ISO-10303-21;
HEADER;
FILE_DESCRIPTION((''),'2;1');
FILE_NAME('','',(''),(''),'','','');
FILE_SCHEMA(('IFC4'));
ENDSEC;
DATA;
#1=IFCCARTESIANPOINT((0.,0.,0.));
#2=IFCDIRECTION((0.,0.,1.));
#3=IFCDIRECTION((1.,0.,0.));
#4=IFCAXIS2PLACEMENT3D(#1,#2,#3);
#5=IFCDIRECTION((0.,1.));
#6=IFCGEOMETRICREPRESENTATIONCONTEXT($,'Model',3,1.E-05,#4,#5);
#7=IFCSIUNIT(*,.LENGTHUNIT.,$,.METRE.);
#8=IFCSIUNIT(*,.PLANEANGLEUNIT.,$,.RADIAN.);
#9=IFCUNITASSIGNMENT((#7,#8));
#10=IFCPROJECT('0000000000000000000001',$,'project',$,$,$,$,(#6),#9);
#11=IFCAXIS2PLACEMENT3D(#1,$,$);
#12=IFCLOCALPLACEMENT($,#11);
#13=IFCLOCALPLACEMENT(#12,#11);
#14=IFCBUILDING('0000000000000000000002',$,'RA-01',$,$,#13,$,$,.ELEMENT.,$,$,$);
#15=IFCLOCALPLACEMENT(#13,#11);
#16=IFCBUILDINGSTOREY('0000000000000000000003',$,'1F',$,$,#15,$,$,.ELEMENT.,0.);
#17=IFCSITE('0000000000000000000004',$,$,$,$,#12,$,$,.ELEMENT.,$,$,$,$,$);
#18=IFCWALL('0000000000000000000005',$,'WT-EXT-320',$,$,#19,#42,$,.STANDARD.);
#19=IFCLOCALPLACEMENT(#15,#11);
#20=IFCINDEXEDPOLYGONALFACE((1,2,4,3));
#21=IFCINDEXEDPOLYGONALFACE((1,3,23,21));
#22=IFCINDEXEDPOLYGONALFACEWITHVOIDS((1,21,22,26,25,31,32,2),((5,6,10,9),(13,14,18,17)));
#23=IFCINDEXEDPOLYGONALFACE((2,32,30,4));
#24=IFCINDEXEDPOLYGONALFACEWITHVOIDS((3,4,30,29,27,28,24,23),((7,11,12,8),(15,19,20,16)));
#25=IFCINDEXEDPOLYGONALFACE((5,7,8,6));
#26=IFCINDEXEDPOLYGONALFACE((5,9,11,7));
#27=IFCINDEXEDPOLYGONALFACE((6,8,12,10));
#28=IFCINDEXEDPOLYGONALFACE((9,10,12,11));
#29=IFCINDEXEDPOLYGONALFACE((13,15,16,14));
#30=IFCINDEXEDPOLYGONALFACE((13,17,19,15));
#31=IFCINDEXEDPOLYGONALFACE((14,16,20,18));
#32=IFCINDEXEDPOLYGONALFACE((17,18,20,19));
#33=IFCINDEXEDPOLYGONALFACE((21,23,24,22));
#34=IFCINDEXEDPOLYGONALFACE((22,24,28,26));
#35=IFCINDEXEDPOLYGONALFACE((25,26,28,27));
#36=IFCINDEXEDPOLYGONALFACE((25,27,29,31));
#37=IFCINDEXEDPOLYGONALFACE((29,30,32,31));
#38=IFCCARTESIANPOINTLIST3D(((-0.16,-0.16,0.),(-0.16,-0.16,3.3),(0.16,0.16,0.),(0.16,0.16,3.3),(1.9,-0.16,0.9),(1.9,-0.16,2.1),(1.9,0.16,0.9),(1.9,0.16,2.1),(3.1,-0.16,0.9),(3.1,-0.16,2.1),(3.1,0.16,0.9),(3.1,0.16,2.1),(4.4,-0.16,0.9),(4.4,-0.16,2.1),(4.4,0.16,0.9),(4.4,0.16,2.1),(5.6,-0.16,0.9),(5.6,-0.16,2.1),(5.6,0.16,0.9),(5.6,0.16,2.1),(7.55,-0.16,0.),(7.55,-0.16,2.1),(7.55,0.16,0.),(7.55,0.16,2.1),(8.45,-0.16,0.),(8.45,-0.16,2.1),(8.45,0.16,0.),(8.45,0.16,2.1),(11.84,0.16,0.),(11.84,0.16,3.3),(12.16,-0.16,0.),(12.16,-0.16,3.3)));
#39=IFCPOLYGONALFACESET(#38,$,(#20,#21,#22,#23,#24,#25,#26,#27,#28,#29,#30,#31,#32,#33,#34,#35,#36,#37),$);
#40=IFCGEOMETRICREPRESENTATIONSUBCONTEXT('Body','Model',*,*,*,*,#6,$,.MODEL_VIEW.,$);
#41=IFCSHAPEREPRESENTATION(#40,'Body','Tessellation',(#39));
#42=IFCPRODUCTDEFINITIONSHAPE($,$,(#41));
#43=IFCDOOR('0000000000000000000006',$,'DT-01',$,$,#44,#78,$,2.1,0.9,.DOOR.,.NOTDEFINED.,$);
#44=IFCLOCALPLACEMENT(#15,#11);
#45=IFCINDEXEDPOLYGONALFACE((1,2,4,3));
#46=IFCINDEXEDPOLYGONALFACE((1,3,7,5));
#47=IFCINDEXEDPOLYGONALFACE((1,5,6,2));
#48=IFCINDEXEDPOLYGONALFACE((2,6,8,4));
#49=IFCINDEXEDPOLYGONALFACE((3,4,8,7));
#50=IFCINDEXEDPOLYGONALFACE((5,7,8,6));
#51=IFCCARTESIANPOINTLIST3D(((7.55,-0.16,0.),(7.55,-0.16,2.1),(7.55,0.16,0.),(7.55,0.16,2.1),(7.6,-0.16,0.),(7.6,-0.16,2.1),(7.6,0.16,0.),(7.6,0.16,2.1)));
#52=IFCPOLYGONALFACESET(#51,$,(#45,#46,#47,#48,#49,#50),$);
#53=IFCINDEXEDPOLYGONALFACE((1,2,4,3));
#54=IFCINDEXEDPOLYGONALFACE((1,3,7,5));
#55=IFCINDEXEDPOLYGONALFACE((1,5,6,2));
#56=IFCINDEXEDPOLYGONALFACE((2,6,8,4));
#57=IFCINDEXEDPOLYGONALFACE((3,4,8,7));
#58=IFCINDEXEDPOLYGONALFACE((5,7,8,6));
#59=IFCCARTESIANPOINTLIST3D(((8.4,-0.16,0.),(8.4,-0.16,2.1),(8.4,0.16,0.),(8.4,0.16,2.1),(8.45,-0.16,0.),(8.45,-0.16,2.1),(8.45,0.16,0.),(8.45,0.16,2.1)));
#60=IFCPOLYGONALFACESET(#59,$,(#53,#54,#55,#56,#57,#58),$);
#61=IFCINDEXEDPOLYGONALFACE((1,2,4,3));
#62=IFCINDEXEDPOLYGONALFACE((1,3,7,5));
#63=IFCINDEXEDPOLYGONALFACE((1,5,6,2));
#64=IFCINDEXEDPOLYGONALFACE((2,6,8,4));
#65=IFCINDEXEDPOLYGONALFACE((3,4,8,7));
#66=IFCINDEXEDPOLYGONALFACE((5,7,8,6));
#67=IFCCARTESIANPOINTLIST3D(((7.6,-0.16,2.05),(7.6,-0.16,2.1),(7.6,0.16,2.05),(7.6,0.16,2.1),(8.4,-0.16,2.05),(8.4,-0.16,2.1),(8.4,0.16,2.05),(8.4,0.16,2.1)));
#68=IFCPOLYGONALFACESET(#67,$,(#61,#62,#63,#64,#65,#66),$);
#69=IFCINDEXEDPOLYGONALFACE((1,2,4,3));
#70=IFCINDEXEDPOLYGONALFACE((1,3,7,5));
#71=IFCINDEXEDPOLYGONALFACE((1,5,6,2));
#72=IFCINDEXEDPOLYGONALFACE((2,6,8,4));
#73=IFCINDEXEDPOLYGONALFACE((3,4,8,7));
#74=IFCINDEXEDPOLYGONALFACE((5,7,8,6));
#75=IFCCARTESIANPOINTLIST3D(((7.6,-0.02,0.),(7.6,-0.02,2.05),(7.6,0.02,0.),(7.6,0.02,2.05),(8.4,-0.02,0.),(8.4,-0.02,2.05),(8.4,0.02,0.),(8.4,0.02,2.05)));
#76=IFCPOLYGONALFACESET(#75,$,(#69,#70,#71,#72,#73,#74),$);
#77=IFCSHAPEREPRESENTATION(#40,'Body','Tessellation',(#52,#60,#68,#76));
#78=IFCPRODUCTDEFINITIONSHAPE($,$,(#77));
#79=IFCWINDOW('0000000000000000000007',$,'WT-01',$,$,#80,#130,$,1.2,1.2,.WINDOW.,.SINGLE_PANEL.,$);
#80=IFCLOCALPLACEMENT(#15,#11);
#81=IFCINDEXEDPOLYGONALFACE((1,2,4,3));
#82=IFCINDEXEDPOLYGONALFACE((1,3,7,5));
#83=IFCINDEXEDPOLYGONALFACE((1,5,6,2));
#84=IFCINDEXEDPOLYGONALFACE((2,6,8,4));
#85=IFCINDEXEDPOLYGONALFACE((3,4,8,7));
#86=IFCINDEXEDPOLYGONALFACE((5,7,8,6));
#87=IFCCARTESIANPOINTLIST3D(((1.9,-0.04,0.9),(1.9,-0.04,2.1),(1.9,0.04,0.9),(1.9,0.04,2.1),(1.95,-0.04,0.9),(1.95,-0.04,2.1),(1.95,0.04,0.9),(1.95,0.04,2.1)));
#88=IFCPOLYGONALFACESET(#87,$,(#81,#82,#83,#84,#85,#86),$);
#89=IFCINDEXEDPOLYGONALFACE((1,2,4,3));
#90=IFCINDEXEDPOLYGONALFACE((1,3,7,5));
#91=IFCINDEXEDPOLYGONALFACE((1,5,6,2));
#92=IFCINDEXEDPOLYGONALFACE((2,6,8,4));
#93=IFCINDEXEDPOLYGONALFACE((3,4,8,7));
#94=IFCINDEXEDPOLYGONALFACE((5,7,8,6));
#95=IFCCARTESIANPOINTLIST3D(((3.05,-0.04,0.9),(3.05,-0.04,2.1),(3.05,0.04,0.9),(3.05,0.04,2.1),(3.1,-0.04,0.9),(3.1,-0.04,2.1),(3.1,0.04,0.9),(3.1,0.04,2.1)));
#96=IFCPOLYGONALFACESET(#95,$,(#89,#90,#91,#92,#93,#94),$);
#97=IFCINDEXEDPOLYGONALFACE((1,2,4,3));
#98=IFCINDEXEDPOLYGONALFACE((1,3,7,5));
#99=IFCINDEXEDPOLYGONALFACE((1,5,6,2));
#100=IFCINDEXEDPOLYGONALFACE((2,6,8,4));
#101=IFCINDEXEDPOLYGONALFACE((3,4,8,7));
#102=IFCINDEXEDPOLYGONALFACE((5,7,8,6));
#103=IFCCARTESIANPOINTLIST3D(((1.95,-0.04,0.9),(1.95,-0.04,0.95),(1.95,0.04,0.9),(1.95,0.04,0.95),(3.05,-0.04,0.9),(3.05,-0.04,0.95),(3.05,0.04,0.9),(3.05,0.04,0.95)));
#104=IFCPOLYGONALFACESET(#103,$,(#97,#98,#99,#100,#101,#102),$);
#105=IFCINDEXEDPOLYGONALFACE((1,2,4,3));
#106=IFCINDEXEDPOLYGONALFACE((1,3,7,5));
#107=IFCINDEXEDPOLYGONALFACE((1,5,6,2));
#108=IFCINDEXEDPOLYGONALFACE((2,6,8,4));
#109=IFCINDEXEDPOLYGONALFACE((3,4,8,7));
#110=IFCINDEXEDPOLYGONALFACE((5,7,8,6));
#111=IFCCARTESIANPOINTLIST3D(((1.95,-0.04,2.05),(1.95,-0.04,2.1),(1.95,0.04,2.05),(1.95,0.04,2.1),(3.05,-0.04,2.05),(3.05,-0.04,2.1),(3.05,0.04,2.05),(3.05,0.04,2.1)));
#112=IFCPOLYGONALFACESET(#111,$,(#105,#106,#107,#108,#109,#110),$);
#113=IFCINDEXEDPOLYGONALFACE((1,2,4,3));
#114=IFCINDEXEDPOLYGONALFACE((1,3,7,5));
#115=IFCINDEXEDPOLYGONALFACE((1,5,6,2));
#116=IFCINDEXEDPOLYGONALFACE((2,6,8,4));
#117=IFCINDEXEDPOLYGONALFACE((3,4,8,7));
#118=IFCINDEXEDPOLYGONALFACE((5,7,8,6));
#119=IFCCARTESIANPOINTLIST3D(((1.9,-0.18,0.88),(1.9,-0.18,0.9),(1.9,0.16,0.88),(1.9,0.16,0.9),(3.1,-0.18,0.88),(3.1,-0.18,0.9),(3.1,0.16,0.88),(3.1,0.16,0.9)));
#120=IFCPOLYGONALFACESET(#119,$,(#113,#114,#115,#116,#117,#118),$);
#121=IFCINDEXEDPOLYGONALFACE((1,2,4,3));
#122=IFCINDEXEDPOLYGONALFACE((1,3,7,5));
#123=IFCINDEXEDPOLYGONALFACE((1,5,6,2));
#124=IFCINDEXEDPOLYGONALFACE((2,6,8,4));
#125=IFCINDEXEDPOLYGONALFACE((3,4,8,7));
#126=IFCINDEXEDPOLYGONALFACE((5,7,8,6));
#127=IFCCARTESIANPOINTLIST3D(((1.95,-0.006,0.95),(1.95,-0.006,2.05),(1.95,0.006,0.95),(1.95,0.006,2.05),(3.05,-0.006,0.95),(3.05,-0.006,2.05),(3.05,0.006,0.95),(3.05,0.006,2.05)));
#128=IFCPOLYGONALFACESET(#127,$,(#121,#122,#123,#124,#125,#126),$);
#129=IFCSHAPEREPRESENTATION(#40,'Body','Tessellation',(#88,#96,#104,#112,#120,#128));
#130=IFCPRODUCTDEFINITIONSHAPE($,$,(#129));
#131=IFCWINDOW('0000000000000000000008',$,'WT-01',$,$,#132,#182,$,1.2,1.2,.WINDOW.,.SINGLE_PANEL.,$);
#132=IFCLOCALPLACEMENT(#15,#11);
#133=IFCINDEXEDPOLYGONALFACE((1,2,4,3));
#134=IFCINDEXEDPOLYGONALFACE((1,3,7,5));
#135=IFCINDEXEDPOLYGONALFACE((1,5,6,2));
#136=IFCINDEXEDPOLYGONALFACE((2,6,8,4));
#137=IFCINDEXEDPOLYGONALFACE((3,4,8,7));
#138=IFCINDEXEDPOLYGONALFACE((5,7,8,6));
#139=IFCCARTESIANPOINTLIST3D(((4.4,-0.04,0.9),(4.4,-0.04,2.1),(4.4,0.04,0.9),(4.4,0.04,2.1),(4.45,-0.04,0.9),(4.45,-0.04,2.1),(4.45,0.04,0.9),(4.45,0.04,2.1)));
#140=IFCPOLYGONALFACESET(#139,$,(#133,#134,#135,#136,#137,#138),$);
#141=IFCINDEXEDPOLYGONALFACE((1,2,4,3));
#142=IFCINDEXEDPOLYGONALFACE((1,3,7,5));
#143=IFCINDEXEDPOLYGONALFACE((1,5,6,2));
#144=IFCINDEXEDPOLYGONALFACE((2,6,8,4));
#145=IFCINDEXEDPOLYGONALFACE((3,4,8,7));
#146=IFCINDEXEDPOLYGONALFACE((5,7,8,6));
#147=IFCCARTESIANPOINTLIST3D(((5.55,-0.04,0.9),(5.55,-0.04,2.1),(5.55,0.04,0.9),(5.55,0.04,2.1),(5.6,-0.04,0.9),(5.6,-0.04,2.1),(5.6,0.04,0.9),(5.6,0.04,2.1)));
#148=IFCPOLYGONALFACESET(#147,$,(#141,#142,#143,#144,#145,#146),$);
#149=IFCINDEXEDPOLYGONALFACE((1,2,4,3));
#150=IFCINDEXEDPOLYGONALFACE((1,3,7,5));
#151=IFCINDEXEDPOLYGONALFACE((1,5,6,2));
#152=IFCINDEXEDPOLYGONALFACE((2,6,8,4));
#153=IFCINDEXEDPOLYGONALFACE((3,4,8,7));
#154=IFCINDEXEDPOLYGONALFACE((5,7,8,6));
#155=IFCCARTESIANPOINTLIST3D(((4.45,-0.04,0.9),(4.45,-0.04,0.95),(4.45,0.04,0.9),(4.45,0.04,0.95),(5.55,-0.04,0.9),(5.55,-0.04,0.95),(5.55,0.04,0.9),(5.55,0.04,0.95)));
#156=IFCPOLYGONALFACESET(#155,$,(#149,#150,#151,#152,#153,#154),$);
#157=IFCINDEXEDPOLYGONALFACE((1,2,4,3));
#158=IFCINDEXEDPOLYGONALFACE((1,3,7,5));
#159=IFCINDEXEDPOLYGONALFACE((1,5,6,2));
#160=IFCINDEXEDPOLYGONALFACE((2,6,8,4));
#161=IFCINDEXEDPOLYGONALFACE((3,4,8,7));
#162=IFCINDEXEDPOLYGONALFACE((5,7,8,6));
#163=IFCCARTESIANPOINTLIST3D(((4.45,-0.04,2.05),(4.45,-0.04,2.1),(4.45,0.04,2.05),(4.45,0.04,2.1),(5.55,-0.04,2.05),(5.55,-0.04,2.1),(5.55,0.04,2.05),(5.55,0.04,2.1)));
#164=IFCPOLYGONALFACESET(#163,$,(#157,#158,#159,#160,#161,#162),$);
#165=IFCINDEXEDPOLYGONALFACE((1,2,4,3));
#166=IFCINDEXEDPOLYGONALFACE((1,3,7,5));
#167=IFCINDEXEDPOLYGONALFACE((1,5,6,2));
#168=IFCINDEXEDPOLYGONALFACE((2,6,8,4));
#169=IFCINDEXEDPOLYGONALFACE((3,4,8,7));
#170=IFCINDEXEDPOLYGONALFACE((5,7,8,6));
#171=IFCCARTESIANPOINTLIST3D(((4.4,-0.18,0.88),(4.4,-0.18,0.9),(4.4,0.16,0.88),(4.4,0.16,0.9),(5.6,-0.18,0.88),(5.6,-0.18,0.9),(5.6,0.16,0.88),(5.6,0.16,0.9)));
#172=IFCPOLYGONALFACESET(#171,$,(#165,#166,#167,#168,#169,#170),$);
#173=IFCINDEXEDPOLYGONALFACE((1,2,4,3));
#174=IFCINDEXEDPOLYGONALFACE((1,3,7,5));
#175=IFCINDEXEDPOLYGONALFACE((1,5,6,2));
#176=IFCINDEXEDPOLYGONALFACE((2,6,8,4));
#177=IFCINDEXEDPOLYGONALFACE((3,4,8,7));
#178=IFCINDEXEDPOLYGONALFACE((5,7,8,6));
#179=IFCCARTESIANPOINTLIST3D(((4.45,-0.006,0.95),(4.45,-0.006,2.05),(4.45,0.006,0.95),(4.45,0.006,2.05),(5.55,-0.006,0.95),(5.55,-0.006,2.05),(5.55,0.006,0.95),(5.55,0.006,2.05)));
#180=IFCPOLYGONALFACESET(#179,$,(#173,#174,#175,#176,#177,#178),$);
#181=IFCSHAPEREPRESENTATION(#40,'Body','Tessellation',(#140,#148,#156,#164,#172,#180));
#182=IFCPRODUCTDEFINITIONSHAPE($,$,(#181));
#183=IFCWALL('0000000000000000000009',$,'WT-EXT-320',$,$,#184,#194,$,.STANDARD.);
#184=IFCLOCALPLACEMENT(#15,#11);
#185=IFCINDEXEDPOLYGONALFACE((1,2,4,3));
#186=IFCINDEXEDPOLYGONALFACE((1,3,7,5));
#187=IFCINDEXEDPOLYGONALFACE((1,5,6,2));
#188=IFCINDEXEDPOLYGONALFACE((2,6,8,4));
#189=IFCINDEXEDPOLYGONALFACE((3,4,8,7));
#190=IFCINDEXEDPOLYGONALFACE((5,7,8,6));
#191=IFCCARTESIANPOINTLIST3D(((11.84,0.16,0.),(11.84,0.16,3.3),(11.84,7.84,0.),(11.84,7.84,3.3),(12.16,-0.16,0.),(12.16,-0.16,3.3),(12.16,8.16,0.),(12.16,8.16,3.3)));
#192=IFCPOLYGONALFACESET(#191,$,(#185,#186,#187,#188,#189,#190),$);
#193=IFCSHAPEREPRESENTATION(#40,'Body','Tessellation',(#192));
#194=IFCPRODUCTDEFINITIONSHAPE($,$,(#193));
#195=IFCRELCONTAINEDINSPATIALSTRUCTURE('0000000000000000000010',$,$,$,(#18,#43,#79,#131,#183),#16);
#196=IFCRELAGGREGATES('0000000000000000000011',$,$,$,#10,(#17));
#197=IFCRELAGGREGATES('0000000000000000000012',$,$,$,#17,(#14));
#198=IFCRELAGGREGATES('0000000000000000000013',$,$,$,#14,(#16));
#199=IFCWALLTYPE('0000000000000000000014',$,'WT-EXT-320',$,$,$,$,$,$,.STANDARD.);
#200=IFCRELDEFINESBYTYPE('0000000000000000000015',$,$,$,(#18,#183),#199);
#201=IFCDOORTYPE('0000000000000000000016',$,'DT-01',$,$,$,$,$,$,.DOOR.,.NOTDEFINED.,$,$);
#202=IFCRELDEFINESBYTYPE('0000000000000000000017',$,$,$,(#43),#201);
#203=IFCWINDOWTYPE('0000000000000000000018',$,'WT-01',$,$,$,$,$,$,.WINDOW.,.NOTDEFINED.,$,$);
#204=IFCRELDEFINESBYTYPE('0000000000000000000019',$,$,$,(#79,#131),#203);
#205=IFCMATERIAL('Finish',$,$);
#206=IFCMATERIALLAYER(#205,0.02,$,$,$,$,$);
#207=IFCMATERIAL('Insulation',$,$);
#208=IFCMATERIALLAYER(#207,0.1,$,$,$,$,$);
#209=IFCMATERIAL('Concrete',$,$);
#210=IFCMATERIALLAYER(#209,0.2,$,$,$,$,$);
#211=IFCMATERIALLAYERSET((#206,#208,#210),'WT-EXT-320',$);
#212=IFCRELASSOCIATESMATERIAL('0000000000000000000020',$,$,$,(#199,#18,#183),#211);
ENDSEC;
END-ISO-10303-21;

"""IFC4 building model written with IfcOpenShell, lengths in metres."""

from ifc_helpers import new_model, si_unit, direction, frame, frame_2d, origin, origin_with_axes, place, context, subcontext, project, spatial, polyline, rectangle, outline, extrude, material, layer, layer_set, layer_usage, type_object, element, fill, save


model = new_model("IFC4")

# Units and contexts
model_context = context("Model", 3, precision=1e-05, world=origin_with_axes(), true_north=direction((0.0, 1.0)))
body_context = subcontext(model_context, "Body", "Model", "MODEL_VIEW")
ifc_project = project(units=[si_unit("LENGTHUNIT", "METRE"), si_unit("PLANEANGLEUNIT", "RADIAN")], contexts=[model_context])

# Site, building, storey
site_placement = place(None, origin())
site = spatial("IfcSite", under=ifc_project, at=site_placement, CompositionType="ELEMENT")
building_placement = place(site_placement, origin())
building = spatial("IfcBuilding", under=site, at=building_placement, Name="RA-01", CompositionType="ELEMENT")
storey_placement = place(building_placement, origin())
storey = spatial("IfcBuildingStorey", under=building, at=storey_placement, Name="1F", CompositionType="ELEMENT", Elevation=0.0)

# Shared definitions
ifc_material_1 = material(Name="Concrete")

# Wall, openings, door, windows
ifc_material_2 = material(Name="Finish")
ifc_layer_1 = layer(ifc_material_2, 0.02)
ifc_material_3 = material(Name="Insulation")
ifc_layer_2 = layer(ifc_material_3, 0.1)
ifc_layer_3 = layer(ifc_material_1, 0.2)
ifc_layer_set_1 = layer_set([ifc_layer_1, ifc_layer_2, ifc_layer_3], Name="WT-EXT-320")
ifc_layer_usage_1 = layer_usage(ifc_layer_set_1, "AXIS2", "NEGATIVE", 0.16)
wall_type_1 = type_object("IfcWallType", Name="WT-EXT-320", PredefinedType="STANDARD", material=ifc_layer_set_1)
wall_1_placement = place(storey_placement, origin())
wall_1 = element("IfcWall", 1, at=wall_1_placement, inside=storey, type_object=wall_type_1, material=ifc_layer_usage_1, Name="WT-EXT-320", PredefinedType="STANDARD", context=body_context, shape_type="SweptSolid", body=[
    extrude(outline(polyline([(-0.16, -0.16), (12.16, -0.16), (11.84, 0.16), (0.16, 0.16), (-0.16, -0.16)])), origin(), (0.0, 0.0, 1.0), 3.3),
])
opening_1_placement = place(wall_1_placement, frame((7.55, 0.0, 0.0)))
opening_1 = element("IfcOpeningElement", 2, at=opening_1_placement, cuts=wall_1, PredefinedType="OPENING", context=body_context, shape_type="SweptSolid", body=[
    extrude(rectangle(XDim=0.9, YDim=0.42, at=frame_2d((0.45, 0.0))), origin(), (0.0, 0.0, 1.0), 2.1),
])
opening_2_placement = place(wall_1_placement, frame((1.9, 0.0, 0.9)))
opening_2 = element("IfcOpeningElement", 3, at=opening_2_placement, cuts=wall_1, PredefinedType="OPENING", context=body_context, shape_type="SweptSolid", body=[
    extrude(rectangle(XDim=1.2, YDim=0.42, at=frame_2d((0.6, 0.0))), origin(), (0.0, 0.0, 1.0), 1.2),
])
opening_3_placement = place(wall_1_placement, frame((4.4, 0.0, 0.9)))
opening_3 = element("IfcOpeningElement", 4, at=opening_3_placement, cuts=wall_1, PredefinedType="OPENING", context=body_context, shape_type="SweptSolid", body=[
    extrude(rectangle(XDim=1.2, YDim=0.42, at=frame_2d((0.6, 0.0))), origin(), (0.0, 0.0, 1.0), 1.2),
])
door_type_1 = type_object("IfcDoorType", Name="DT-01", OperationType="NOTDEFINED", PredefinedType="DOOR")
door_1_placement = place(opening_1_placement, origin())
door_1 = element("IfcDoor", 5, at=door_1_placement, inside=storey, type_object=door_type_1, Name="DT-01", OperationType="NOTDEFINED", OverallHeight=2.1, OverallWidth=0.9, PredefinedType="DOOR", context=body_context, shape_type="SweptSolid", body=[
    extrude(outline(polyline([(0.0, -0.16), (0.05, -0.16), (0.05, 0.16), (0.0, 0.16), (0.0, -0.16)])), origin(), (0.0, 0.0, 1.0), 2.1),
    extrude(outline(polyline([(0.85, -0.16), (0.9, -0.16), (0.9, 0.16), (0.85, 0.16), (0.85, -0.16)])), origin(), (0.0, 0.0, 1.0), 2.1),
    extrude(outline(polyline([(0.05, -0.16), (0.85, -0.16), (0.85, 0.16), (0.05, 0.16), (0.05, -0.16)])), frame((0.0, 0.0, 2.05)), (0.0, 0.0, 1.0), 0.05),
    extrude(outline(polyline([(0.05, -0.02), (0.85, -0.02), (0.85, 0.02), (0.05, 0.02), (0.05, -0.02)])), origin(), (0.0, 0.0, 1.0), 2.05),
])
fill(opening_1, door_1)
window_type_1 = type_object("IfcWindowType", Name="WT-01", PartitioningType="NOTDEFINED", PredefinedType="WINDOW")
window_1_placement = place(opening_2_placement, origin())
window_1 = element("IfcWindow", 6, at=window_1_placement, inside=storey, type_object=window_type_1, Name="WT-01", OverallHeight=1.2, OverallWidth=1.2, PartitioningType="SINGLE_PANEL", PredefinedType="WINDOW", context=body_context, shape_type="SweptSolid", body=[
    extrude(outline(polyline([(0.0, -0.04), (0.05, -0.04), (0.05, 0.04), (0.0, 0.04), (0.0, -0.04)])), origin(), (0.0, 0.0, 1.0), 1.2),
    extrude(outline(polyline([(1.15, -0.04), (1.2, -0.04), (1.2, 0.04), (1.15, 0.04), (1.15, -0.04)])), origin(), (0.0, 0.0, 1.0), 1.2),
    extrude(outline(polyline([(0.05, -0.04), (1.15, -0.04), (1.15, 0.04), (0.05, 0.04), (0.05, -0.04)])), origin(), (0.0, 0.0, 1.0), 0.05),
    extrude(outline(polyline([(0.05, -0.04), (1.15, -0.04), (1.15, 0.04), (0.05, 0.04), (0.05, -0.04)])), frame((0.0, 0.0, 1.15)), (0.0, 0.0, 1.0), 0.05),
    extrude(outline(polyline([(0.0, -0.18), (1.2, -0.18), (1.2, 0.16), (0.0, 0.16), (0.0, -0.18)])), frame((0.0, 0.0, -0.02)), (0.0, 0.0, 1.0), 0.02),
    extrude(outline(polyline([(0.05, -0.006), (1.15, -0.006), (1.15, 0.006), (0.05, 0.006), (0.05, -0.006)])), frame((0.0, 0.0, 0.05)), (0.0, 0.0, 1.0), 1.1),
])
fill(opening_2, window_1)
window_2_placement = place(opening_3_placement, origin())
window_2 = element("IfcWindow", 7, at=window_2_placement, inside=storey, type_object=window_type_1, Name="WT-01", OverallHeight=1.2, OverallWidth=1.2, PartitioningType="SINGLE_PANEL", PredefinedType="WINDOW", context=body_context, shape_type="SweptSolid", body=[
    extrude(outline(polyline([(0.0, -0.04), (0.05, -0.04), (0.05, 0.04), (0.0, 0.04), (0.0, -0.04)])), origin(), (0.0, 0.0, 1.0), 1.2),
    extrude(outline(polyline([(1.15, -0.04), (1.2, -0.04), (1.2, 0.04), (1.15, 0.04), (1.15, -0.04)])), origin(), (0.0, 0.0, 1.0), 1.2),
    extrude(outline(polyline([(0.05, -0.04), (1.15, -0.04), (1.15, 0.04), (0.05, 0.04), (0.05, -0.04)])), origin(), (0.0, 0.0, 1.0), 0.05),
    extrude(outline(polyline([(0.05, -0.04), (1.15, -0.04), (1.15, 0.04), (0.05, 0.04), (0.05, -0.04)])), frame((0.0, 0.0, 1.15)), (0.0, 0.0, 1.0), 0.05),
    extrude(outline(polyline([(0.0, -0.18), (1.2, -0.18), (1.2, 0.16), (0.0, 0.16), (0.0, -0.18)])), frame((0.0, 0.0, -0.02)), (0.0, 0.0, 1.0), 0.02),
    extrude(outline(polyline([(0.05, -0.006), (1.15, -0.006), (1.15, 0.006), (0.05, 0.006), (0.05, -0.006)])), frame((0.0, 0.0, 0.05)), (0.0, 0.0, 1.0), 1.1),
])
fill(opening_3, window_2)

# Wall
wall_2_placement = place(storey_placement, frame((12.0, 0.0, 0.0), z_axis=(0.0, 0.0, 1.0), x_axis=(0.0, 1.0, 0.0)))
element("IfcWall", 8, at=wall_2_placement, inside=storey, type_object=wall_type_1, material=ifc_layer_usage_1, Name="WT-EXT-320", PredefinedType="STANDARD", context=body_context, shape_type="SweptSolid", body=[
    extrude(outline(polyline([(-0.16, -0.16), (8.16, -0.16), (7.84, 0.16), (0.16, 0.16), (-0.16, -0.16)])), origin(), (0.0, 0.0, 1.0), 3.3),
])

save(model, "model.ifc")
